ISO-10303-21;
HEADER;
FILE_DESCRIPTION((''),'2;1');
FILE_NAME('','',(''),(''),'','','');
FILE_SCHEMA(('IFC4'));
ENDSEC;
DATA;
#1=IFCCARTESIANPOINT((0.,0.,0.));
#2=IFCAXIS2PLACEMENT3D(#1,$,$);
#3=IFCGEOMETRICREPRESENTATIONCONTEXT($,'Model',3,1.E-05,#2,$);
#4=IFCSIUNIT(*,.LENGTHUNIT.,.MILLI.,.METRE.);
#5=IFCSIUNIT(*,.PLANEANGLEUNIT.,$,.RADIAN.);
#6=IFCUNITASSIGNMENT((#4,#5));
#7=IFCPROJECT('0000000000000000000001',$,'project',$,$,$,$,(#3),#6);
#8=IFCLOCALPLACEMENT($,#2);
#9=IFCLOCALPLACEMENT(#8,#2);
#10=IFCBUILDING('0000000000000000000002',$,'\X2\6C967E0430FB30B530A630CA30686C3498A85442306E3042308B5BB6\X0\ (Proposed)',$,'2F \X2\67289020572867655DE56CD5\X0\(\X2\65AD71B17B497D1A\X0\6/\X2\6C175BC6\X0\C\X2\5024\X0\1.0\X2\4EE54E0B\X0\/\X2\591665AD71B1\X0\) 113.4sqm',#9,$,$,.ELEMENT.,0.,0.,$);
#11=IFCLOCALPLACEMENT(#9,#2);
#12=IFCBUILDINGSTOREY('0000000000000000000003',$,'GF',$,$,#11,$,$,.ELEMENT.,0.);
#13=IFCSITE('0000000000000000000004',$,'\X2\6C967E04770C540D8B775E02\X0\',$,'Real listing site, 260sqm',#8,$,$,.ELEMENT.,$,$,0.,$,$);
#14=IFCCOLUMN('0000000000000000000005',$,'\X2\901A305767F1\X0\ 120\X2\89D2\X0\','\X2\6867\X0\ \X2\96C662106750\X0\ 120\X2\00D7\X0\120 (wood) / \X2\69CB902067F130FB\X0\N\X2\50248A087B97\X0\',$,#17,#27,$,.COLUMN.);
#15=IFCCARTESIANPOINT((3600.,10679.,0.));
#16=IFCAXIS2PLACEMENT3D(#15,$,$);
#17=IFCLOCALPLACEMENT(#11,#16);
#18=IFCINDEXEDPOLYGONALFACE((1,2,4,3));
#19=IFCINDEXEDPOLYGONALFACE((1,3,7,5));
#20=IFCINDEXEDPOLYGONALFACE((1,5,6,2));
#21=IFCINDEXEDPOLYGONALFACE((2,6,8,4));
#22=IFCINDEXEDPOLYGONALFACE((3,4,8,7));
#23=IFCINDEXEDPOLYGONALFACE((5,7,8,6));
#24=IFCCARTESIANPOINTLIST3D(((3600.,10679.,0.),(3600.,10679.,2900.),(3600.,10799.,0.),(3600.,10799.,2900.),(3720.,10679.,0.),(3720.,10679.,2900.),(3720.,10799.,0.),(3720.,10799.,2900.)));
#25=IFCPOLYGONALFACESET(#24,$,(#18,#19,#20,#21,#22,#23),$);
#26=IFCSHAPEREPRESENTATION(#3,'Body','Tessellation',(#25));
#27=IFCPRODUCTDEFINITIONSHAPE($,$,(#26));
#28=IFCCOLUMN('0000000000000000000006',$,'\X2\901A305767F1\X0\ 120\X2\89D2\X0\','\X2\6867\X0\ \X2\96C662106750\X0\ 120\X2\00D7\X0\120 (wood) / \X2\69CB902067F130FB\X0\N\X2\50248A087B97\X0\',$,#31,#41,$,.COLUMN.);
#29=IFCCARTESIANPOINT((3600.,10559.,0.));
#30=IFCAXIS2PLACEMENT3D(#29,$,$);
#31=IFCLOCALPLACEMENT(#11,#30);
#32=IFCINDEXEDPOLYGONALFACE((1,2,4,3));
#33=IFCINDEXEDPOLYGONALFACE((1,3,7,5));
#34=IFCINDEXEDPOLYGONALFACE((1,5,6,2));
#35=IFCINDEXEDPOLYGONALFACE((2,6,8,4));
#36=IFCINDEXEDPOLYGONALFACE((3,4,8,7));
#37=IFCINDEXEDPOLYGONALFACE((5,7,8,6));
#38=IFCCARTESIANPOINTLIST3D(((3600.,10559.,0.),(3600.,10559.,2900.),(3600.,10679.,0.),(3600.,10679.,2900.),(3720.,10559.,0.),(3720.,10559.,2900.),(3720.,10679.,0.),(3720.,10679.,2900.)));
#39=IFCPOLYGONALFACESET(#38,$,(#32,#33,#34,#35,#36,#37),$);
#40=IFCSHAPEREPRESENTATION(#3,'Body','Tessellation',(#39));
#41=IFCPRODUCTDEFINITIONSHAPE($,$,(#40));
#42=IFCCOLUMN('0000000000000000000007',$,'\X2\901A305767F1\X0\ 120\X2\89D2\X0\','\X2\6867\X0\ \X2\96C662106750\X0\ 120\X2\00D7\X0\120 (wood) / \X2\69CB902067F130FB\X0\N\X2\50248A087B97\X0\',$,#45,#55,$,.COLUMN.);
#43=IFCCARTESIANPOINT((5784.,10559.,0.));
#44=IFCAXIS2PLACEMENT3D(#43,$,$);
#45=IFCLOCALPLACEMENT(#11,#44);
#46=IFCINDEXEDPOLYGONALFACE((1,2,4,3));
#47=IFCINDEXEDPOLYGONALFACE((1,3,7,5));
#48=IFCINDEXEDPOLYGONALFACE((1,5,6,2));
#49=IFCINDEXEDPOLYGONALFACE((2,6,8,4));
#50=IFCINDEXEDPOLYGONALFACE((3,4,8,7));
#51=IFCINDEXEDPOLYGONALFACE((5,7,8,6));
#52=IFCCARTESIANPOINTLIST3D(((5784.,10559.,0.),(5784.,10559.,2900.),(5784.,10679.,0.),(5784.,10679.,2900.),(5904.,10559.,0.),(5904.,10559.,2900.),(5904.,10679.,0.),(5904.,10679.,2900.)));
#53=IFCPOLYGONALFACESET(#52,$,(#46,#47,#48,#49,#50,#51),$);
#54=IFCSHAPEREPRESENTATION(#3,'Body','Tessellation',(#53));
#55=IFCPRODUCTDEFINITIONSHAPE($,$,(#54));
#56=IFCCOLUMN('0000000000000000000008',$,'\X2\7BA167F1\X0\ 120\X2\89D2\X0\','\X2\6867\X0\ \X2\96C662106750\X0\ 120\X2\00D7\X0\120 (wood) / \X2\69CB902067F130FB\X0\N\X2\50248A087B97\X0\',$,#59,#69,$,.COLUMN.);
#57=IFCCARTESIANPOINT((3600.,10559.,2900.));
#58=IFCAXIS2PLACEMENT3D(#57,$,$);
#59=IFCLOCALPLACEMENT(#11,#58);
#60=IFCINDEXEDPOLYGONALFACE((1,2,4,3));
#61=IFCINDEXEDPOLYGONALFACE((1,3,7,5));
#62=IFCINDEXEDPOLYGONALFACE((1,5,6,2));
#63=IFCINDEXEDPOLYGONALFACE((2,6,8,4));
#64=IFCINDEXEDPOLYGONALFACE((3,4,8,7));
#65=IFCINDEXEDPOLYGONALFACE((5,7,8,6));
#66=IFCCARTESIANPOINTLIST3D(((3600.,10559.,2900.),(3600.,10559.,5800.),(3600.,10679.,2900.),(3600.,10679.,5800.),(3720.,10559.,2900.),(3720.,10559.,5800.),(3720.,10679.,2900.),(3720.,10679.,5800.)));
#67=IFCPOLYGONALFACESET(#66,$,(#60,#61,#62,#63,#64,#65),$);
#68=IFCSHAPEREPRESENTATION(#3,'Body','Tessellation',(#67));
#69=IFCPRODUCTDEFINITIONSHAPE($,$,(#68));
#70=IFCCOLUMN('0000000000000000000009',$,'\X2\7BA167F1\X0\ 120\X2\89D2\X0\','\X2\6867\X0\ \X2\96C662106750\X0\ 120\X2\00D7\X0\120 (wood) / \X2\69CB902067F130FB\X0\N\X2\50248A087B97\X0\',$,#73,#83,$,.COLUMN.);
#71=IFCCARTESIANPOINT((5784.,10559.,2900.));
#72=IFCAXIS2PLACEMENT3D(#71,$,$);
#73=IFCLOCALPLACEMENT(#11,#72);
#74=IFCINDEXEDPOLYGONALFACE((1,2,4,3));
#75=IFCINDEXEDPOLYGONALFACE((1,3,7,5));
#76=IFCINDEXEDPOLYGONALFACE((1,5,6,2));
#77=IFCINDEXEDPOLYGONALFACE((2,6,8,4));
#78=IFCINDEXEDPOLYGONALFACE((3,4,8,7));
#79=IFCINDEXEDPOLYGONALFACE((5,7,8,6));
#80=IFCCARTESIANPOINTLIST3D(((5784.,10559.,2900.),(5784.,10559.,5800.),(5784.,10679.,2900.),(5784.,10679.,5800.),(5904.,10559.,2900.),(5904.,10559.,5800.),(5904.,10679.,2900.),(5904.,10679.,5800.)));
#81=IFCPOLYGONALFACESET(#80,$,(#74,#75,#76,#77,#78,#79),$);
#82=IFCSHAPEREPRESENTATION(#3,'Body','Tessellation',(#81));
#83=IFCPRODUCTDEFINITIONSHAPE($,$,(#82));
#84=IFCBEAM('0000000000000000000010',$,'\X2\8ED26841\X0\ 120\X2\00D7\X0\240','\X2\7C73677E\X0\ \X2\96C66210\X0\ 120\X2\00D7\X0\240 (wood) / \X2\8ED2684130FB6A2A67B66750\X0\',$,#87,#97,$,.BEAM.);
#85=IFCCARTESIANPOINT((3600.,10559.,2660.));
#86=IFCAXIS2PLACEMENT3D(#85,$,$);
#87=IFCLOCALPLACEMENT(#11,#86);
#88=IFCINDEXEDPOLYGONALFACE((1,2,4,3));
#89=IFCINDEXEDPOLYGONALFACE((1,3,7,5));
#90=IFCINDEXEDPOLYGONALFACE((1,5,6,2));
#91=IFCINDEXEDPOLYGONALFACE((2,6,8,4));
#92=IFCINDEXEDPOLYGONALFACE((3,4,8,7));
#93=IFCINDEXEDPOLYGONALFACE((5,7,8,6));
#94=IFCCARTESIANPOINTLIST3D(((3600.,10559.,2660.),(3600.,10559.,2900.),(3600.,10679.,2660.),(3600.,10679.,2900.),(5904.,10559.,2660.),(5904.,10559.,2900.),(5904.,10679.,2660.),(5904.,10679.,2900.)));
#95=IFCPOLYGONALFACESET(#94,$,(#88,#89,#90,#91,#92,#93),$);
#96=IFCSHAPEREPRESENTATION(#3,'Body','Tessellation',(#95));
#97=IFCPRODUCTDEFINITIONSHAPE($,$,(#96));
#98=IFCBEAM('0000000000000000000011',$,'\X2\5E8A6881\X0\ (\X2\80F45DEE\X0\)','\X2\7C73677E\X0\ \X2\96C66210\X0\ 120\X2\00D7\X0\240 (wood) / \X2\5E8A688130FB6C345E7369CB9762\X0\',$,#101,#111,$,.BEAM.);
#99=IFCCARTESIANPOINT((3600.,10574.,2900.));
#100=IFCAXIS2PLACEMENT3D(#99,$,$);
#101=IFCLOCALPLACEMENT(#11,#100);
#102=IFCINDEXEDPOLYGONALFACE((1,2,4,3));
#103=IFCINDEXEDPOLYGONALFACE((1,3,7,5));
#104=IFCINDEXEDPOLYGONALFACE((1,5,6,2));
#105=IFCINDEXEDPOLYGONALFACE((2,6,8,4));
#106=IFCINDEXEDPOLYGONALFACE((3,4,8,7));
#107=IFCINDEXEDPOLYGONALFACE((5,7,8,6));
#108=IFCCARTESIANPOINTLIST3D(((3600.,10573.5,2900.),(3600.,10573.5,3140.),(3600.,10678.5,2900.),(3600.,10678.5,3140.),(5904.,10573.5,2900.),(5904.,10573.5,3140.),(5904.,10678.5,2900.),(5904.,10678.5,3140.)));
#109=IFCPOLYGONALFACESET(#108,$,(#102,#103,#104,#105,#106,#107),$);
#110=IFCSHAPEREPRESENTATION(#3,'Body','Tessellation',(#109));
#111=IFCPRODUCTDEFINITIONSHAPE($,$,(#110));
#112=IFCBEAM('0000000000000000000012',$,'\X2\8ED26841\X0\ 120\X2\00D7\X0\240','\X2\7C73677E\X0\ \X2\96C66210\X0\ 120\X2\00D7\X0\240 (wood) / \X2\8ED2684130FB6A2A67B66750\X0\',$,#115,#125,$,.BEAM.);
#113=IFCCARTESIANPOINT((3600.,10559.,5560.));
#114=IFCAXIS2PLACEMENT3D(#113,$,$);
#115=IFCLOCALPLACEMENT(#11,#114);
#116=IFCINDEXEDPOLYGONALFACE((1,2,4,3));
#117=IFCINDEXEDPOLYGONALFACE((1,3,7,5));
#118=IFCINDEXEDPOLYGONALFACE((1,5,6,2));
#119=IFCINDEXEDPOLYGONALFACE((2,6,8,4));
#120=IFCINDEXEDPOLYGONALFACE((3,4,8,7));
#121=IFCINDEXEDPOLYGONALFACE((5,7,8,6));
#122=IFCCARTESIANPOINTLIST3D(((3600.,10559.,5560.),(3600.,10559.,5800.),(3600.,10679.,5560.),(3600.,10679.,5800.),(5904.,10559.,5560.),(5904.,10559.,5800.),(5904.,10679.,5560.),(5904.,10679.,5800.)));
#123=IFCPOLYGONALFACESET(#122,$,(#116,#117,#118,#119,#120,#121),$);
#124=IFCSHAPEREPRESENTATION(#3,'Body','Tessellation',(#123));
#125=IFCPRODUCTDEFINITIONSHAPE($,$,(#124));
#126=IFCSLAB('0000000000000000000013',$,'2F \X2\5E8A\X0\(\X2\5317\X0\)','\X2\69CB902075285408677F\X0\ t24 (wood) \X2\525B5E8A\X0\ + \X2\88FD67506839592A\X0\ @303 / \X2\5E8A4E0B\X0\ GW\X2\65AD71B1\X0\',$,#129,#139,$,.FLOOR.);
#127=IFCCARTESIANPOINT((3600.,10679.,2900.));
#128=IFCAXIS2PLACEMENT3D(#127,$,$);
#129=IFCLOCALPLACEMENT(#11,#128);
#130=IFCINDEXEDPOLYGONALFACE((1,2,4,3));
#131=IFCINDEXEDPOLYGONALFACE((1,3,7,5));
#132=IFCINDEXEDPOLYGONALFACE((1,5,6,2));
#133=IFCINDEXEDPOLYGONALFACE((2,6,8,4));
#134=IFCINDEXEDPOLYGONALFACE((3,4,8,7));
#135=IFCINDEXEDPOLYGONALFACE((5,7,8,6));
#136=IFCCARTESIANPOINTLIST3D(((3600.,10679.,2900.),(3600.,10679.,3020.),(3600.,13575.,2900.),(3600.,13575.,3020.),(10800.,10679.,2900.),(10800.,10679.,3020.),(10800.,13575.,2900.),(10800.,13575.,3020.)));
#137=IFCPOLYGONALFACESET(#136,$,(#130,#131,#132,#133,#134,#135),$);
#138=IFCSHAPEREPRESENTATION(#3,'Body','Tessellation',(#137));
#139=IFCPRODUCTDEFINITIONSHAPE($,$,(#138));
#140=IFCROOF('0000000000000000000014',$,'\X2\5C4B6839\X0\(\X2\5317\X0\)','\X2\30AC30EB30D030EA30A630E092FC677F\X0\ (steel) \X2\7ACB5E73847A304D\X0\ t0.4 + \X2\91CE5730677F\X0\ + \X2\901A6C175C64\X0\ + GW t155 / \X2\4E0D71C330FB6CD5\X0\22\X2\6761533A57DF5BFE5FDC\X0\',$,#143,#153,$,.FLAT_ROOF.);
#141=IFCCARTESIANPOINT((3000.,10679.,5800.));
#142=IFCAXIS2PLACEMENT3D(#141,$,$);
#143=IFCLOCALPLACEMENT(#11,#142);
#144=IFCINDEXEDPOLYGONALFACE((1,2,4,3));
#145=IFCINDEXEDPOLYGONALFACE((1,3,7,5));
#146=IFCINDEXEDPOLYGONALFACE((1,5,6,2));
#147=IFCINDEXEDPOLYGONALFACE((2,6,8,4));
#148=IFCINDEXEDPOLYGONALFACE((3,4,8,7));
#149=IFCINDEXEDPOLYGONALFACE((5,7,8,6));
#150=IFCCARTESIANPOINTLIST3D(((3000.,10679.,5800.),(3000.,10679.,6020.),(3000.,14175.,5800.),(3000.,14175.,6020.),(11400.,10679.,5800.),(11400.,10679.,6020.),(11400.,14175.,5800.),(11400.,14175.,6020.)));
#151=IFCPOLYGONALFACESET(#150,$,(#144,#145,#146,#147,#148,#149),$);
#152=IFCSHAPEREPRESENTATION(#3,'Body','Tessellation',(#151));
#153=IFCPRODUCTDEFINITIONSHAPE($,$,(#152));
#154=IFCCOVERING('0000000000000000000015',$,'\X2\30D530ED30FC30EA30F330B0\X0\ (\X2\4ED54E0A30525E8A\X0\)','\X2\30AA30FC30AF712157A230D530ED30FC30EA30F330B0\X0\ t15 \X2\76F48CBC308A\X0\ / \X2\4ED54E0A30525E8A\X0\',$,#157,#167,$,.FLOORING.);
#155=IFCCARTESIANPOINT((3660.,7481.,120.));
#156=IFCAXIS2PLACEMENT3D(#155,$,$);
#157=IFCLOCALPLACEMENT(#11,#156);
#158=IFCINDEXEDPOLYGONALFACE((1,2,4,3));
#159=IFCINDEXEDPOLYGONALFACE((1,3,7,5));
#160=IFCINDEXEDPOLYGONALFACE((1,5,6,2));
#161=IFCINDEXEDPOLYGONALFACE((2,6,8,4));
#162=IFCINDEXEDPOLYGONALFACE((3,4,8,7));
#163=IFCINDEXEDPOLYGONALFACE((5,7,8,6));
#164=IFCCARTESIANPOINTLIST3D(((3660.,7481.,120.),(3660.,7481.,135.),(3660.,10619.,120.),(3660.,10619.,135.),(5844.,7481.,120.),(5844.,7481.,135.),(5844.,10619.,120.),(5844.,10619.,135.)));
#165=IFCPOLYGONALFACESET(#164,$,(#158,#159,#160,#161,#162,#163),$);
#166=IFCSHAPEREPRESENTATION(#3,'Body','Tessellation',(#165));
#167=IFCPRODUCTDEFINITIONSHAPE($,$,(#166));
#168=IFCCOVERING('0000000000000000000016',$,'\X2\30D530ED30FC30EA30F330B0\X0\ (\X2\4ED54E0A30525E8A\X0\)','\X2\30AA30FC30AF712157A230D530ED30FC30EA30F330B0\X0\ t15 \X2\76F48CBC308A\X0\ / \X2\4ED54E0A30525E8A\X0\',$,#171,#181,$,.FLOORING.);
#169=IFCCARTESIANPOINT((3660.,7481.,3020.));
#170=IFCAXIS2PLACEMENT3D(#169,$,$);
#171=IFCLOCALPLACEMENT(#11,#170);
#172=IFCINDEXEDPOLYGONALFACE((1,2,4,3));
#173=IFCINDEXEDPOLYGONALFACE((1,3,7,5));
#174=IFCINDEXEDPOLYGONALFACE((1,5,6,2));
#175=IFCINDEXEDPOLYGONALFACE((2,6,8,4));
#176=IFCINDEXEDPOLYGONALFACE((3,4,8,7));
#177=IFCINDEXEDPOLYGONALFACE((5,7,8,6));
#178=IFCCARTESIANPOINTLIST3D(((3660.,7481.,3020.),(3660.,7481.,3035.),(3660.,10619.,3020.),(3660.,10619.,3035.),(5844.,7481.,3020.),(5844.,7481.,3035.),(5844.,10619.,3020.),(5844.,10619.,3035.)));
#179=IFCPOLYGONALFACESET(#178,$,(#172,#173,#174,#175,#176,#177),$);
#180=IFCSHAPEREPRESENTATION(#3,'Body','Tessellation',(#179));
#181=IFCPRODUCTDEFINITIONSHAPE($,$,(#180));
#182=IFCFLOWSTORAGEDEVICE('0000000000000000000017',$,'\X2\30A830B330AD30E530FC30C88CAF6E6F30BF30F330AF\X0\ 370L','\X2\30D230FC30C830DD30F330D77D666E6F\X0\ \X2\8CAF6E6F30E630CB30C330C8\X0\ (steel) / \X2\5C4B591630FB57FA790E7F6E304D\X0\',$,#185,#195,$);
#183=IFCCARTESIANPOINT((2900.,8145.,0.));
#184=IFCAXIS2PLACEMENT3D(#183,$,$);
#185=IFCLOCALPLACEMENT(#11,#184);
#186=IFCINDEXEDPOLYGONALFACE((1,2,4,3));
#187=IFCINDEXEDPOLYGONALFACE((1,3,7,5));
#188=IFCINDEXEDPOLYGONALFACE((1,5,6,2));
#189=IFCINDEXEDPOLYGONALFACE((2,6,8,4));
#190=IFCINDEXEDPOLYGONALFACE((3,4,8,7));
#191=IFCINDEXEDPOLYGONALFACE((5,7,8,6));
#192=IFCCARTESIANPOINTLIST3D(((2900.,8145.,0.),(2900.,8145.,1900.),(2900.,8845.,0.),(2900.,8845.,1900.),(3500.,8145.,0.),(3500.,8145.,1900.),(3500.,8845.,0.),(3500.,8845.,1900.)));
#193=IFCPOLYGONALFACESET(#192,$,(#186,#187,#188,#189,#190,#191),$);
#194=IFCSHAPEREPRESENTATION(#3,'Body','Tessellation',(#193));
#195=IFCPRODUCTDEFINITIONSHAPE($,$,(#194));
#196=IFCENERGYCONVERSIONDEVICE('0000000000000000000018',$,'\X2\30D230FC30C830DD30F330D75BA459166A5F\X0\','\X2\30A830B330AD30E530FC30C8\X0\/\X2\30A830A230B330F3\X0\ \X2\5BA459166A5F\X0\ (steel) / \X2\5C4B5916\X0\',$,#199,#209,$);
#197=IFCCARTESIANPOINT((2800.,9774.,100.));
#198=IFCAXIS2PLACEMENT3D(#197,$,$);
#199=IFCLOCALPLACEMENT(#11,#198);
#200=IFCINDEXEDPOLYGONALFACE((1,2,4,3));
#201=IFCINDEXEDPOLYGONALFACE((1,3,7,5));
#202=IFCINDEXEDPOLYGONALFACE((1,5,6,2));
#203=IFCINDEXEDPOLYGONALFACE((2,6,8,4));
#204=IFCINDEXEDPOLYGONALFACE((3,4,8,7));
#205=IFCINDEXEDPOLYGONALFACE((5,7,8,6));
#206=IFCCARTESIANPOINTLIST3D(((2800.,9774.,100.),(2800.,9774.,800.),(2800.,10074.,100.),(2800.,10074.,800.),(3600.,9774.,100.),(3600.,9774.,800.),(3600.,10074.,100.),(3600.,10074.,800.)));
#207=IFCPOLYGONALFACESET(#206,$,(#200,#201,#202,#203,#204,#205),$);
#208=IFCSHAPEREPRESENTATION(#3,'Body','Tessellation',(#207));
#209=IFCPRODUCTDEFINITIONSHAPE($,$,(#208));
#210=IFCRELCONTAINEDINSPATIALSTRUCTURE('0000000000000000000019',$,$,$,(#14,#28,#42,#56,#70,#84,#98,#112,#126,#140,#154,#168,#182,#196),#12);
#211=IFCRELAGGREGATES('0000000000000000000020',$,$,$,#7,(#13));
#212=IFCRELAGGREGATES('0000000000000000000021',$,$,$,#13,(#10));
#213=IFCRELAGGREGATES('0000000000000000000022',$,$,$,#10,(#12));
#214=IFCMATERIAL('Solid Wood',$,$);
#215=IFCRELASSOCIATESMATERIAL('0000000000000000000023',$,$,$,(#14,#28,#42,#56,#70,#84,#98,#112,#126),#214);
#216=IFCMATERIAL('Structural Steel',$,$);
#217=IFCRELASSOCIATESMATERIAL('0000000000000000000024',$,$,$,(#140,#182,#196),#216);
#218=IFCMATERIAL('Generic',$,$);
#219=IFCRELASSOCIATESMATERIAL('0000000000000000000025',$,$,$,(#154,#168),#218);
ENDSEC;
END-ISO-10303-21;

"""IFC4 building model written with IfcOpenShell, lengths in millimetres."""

from ifc_helpers import new_model, si_unit, frame, frame_2d, origin, place, context, project, spatial, rectangle, extrude, material, element, save


model = new_model("IFC4")

# Units and contexts
model_context = context("Model", 3, precision=1e-05, world=origin())
ifc_project = project(units=[si_unit("LENGTHUNIT", "METRE", prefix="MILLI"), si_unit("PLANEANGLEUNIT", "RADIAN")], contexts=[model_context])

# Site, building, storey
site_placement = place(None, origin())
site = spatial("IfcSite", under=ifc_project, at=site_placement, Name="沖縄県名護市", ObjectType="Real listing site, 260sqm", CompositionType="ELEMENT", RefElevation=0.0)
building_placement = place(site_placement, origin())
building = spatial("IfcBuilding", under=site, at=building_placement, Name="沖縄・サウナと水風呂のある家 (Proposed)", ObjectType="2F 木造在来工法(断熱等級6/気密C値1.0以下/外断熱) 113.4sqm", CompositionType="ELEMENT", ElevationOfRefHeight=0.0, ElevationOfTerrain=0.0)
storey_placement = place(building_placement, origin())
storey = spatial("IfcBuildingStorey", under=building, at=storey_placement, Name="GF", CompositionType="ELEMENT", Elevation=0.0)

# Columns
ifc_material_1 = material(Name="Solid Wood")
column_1_placement = place(storey_placement, frame((3600.0, 10679.0, 0.0)))
element("IfcColumn", 1, at=column_1_placement, inside=storey, material=ifc_material_1, Name="通し柱 120角", Description="桧 集成材 120×120 (wood) / 構造柱・N値計算", PredefinedType="COLUMN", context=model_context, shape_type="SweptSolid", body=[
    extrude(rectangle(XDim=120.0, YDim=120.0, at=frame_2d((60.0, 60.0))), frame((3600.0, 10679.0, 0.0)), (0.0, 0.0, 1.0), 2900.0),
])
column_2_placement = place(storey_placement, frame((3600.0, 10559.0, 0.0)))
element("IfcColumn", 2, at=column_2_placement, inside=storey, material=ifc_material_1, Name="通し柱 120角", Description="桧 集成材 120×120 (wood) / 構造柱・N値計算", PredefinedType="COLUMN", context=model_context, shape_type="SweptSolid", body=[
    extrude(rectangle(XDim=120.0, YDim=120.0, at=frame_2d((60.0, 60.0))), frame((3600.0, 10559.0, 0.0)), (0.0, 0.0, 1.0), 2900.0),
])
column_3_placement = place(storey_placement, frame((5784.0, 10559.0, 0.0)))
element("IfcColumn", 3, at=column_3_placement, inside=storey, material=ifc_material_1, Name="通し柱 120角", Description="桧 集成材 120×120 (wood) / 構造柱・N値計算", PredefinedType="COLUMN", context=model_context, shape_type="SweptSolid", body=[
    extrude(rectangle(XDim=120.0, YDim=120.0, at=frame_2d((60.0, 60.0))), frame((5784.0, 10559.0, 0.0)), (0.0, 0.0, 1.0), 2900.0),
])
column_4_placement = place(storey_placement, frame((3600.0, 10559.0, 2900.0)))
element("IfcColumn", 4, at=column_4_placement, inside=storey, material=ifc_material_1, Name="管柱 120角", Description="桧 集成材 120×120 (wood) / 構造柱・N値計算", PredefinedType="COLUMN", context=model_context, shape_type="SweptSolid", body=[
    extrude(rectangle(XDim=120.0, YDim=120.0, at=frame_2d((60.0, 60.0))), frame((3600.0, 10559.0, 2900.0)), (0.0, 0.0, 1.0), 2900.0),
])
column_5_placement = place(storey_placement, frame((5784.0, 10559.0, 2900.0)))
element("IfcColumn", 5, at=column_5_placement, inside=storey, material=ifc_material_1, Name="管柱 120角", Description="桧 集成材 120×120 (wood) / 構造柱・N値計算", PredefinedType="COLUMN", context=model_context, shape_type="SweptSolid", body=[
    extrude(rectangle(XDim=120.0, YDim=120.0, at=frame_2d((60.0, 60.0))), frame((5784.0, 10559.0, 2900.0)), (0.0, 0.0, 1.0), 2900.0),
])

# Beams
beam_1_placement = place(storey_placement, frame((3600.0, 10559.0, 2660.0)))
element("IfcBeam", 6, at=beam_1_placement, inside=storey, material=ifc_material_1, Name="軒桁 120×240", Description="米松 集成 120×240 (wood) / 軒桁・横架材", PredefinedType="BEAM", context=model_context, shape_type="SweptSolid", body=[
    extrude(rectangle(XDim=2304.0, YDim=120.0, at=frame_2d((1152.0, 60.0))), frame((3600.0, 10559.0, 2660.0)), (0.0, 0.0, 1.0), 240.0),
])
beam_2_placement = place(storey_placement, frame((3600.0, 10574.0, 2900.0)))
element("IfcBeam", 7, at=beam_2_placement, inside=storey, material=ifc_material_1, Name="床梁 (胴差)", Description="米松 集成 120×240 (wood) / 床梁・水平構面", PredefinedType="BEAM", context=model_context, shape_type="SweptSolid", body=[
    extrude(rectangle(XDim=2304.0, YDim=105.0, at=frame_2d((1152.0, 52.0))), frame((3600.0, 10574.0, 2900.0)), (0.0, 0.0, 1.0), 240.0),
])
beam_3_placement = place(storey_placement, frame((3600.0, 10559.0, 5560.0)))
element("IfcBeam", 8, at=beam_3_placement, inside=storey, material=ifc_material_1, Name="軒桁 120×240", Description="米松 集成 120×240 (wood) / 軒桁・横架材", PredefinedType="BEAM", context=model_context, shape_type="SweptSolid", body=[
    extrude(rectangle(XDim=2304.0, YDim=120.0, at=frame_2d((1152.0, 60.0))), frame((3600.0, 10559.0, 5560.0)), (0.0, 0.0, 1.0), 240.0),
])

# Slab
slab_1_placement = place(storey_placement, frame((3600.0, 10679.0, 2900.0)))
element("IfcSlab", 9, at=slab_1_placement, inside=storey, material=ifc_material_1, Name="2F 床(北)", Description="構造用合板 t24 (wood) 剛床 + 製材根太 @303 / 床下 GW断熱", PredefinedType="FLOOR", context=model_context, shape_type="SweptSolid", body=[
    extrude(rectangle(XDim=7200.0, YDim=2896.0, at=frame_2d((3600.0, 1448.0))), frame((3600.0, 10679.0, 2900.0)), (0.0, 0.0, 1.0), 120.0),
])

# Roof
ifc_material_2 = material(Name="Structural Steel")
for number, where, name in (
    (10, (3000.0, 10679.0, 5800.0), "屋根(北)"),
):
    element("IfcRoof", number, at=place(storey_placement, frame(where)), inside=storey, material=ifc_material_2, Name=name, Description="ガルバリウム鋼板 (steel) 立平葺き t0.4 + 野地板 + 通気層 + GW t155 / 不燃・法22条区域対応", PredefinedType="FLAT_ROOF", context=model_context, shape_type="SweptSolid", body=[
        extrude(rectangle(XDim=8400.0, YDim=3496.0, at=frame_2d((4200.0, 1748.0))), frame((3000.0, 10679.0, 5800.0)), (0.0, 0.0, 1.0), 220.0),
    ])

# Coverings
ifc_material_3 = material(Name="Generic")
covering_1_placement = place(storey_placement, frame((3660.0, 7481.0, 120.0)))
element("IfcCovering", 11, at=covering_1_placement, inside=storey, material=ifc_material_3, Name="フローリング (仕上げ床)", Description="オーク無垢フローリング t15 直貼り / 仕上げ床", PredefinedType="FLOORING", context=model_context, shape_type="SweptSolid", body=[
    extrude(rectangle(XDim=2184.0, YDim=3138.0, at=frame_2d((1092.0, 1569.0))), frame((3660.0, 7481.0, 120.0)), (0.0, 0.0, 1.0), 15.0),
])
covering_2_placement = place(storey_placement, frame((3660.0, 7481.0, 3020.0)))
element("IfcCovering", 12, at=covering_2_placement, inside=storey, material=ifc_material_3, Name="フローリング (仕上げ床)", Description="オーク無垢フローリング t15 直貼り / 仕上げ床", PredefinedType="FLOORING", context=model_context, shape_type="SweptSolid", body=[
    extrude(rectangle(XDim=2184.0, YDim=3138.0, at=frame_2d((1092.0, 1569.0))), frame((3660.0, 7481.0, 3020.0)), (0.0, 0.0, 1.0), 15.0),
])

# Flow storage device
flow_storage_device_placement = place(storey_placement, frame((2900.0, 8145.0, 0.0)))
element("IfcFlowStorageDevice", 13, at=flow_storage_device_placement, inside=storey, material=ifc_material_2, Name="エコキュート貯湯タンク 370L", Description="ヒートポンプ給湯 貯湯ユニット (steel) / 屋外・基礎置き", context=model_context, shape_type="SweptSolid", body=[
    extrude(rectangle(XDim=600.0, YDim=700.0, at=frame_2d((300.0, 350.0))), frame((2900.0, 8145.0, 0.0)), (0.0, 0.0, 1.0), 1900.0),
])

# Energy conversion device
energy_conversion_device_placement = place(storey_placement, frame((2800.0, 9774.0, 100.0)))
element("IfcEnergyConversionDevice", 14, at=energy_conversion_device_placement, inside=storey, material=ifc_material_2, Name="ヒートポンプ室外機", Description="エコキュート/エアコン 室外機 (steel) / 屋外", context=model_context, shape_type="SweptSolid", body=[
    extrude(rectangle(XDim=800.0, YDim=300.0, at=frame_2d((400.0, 150.0))), frame((2800.0, 9774.0, 100.0)), (0.0, 0.0, 1.0), 700.0),
])

save(model, "model.ifc")
